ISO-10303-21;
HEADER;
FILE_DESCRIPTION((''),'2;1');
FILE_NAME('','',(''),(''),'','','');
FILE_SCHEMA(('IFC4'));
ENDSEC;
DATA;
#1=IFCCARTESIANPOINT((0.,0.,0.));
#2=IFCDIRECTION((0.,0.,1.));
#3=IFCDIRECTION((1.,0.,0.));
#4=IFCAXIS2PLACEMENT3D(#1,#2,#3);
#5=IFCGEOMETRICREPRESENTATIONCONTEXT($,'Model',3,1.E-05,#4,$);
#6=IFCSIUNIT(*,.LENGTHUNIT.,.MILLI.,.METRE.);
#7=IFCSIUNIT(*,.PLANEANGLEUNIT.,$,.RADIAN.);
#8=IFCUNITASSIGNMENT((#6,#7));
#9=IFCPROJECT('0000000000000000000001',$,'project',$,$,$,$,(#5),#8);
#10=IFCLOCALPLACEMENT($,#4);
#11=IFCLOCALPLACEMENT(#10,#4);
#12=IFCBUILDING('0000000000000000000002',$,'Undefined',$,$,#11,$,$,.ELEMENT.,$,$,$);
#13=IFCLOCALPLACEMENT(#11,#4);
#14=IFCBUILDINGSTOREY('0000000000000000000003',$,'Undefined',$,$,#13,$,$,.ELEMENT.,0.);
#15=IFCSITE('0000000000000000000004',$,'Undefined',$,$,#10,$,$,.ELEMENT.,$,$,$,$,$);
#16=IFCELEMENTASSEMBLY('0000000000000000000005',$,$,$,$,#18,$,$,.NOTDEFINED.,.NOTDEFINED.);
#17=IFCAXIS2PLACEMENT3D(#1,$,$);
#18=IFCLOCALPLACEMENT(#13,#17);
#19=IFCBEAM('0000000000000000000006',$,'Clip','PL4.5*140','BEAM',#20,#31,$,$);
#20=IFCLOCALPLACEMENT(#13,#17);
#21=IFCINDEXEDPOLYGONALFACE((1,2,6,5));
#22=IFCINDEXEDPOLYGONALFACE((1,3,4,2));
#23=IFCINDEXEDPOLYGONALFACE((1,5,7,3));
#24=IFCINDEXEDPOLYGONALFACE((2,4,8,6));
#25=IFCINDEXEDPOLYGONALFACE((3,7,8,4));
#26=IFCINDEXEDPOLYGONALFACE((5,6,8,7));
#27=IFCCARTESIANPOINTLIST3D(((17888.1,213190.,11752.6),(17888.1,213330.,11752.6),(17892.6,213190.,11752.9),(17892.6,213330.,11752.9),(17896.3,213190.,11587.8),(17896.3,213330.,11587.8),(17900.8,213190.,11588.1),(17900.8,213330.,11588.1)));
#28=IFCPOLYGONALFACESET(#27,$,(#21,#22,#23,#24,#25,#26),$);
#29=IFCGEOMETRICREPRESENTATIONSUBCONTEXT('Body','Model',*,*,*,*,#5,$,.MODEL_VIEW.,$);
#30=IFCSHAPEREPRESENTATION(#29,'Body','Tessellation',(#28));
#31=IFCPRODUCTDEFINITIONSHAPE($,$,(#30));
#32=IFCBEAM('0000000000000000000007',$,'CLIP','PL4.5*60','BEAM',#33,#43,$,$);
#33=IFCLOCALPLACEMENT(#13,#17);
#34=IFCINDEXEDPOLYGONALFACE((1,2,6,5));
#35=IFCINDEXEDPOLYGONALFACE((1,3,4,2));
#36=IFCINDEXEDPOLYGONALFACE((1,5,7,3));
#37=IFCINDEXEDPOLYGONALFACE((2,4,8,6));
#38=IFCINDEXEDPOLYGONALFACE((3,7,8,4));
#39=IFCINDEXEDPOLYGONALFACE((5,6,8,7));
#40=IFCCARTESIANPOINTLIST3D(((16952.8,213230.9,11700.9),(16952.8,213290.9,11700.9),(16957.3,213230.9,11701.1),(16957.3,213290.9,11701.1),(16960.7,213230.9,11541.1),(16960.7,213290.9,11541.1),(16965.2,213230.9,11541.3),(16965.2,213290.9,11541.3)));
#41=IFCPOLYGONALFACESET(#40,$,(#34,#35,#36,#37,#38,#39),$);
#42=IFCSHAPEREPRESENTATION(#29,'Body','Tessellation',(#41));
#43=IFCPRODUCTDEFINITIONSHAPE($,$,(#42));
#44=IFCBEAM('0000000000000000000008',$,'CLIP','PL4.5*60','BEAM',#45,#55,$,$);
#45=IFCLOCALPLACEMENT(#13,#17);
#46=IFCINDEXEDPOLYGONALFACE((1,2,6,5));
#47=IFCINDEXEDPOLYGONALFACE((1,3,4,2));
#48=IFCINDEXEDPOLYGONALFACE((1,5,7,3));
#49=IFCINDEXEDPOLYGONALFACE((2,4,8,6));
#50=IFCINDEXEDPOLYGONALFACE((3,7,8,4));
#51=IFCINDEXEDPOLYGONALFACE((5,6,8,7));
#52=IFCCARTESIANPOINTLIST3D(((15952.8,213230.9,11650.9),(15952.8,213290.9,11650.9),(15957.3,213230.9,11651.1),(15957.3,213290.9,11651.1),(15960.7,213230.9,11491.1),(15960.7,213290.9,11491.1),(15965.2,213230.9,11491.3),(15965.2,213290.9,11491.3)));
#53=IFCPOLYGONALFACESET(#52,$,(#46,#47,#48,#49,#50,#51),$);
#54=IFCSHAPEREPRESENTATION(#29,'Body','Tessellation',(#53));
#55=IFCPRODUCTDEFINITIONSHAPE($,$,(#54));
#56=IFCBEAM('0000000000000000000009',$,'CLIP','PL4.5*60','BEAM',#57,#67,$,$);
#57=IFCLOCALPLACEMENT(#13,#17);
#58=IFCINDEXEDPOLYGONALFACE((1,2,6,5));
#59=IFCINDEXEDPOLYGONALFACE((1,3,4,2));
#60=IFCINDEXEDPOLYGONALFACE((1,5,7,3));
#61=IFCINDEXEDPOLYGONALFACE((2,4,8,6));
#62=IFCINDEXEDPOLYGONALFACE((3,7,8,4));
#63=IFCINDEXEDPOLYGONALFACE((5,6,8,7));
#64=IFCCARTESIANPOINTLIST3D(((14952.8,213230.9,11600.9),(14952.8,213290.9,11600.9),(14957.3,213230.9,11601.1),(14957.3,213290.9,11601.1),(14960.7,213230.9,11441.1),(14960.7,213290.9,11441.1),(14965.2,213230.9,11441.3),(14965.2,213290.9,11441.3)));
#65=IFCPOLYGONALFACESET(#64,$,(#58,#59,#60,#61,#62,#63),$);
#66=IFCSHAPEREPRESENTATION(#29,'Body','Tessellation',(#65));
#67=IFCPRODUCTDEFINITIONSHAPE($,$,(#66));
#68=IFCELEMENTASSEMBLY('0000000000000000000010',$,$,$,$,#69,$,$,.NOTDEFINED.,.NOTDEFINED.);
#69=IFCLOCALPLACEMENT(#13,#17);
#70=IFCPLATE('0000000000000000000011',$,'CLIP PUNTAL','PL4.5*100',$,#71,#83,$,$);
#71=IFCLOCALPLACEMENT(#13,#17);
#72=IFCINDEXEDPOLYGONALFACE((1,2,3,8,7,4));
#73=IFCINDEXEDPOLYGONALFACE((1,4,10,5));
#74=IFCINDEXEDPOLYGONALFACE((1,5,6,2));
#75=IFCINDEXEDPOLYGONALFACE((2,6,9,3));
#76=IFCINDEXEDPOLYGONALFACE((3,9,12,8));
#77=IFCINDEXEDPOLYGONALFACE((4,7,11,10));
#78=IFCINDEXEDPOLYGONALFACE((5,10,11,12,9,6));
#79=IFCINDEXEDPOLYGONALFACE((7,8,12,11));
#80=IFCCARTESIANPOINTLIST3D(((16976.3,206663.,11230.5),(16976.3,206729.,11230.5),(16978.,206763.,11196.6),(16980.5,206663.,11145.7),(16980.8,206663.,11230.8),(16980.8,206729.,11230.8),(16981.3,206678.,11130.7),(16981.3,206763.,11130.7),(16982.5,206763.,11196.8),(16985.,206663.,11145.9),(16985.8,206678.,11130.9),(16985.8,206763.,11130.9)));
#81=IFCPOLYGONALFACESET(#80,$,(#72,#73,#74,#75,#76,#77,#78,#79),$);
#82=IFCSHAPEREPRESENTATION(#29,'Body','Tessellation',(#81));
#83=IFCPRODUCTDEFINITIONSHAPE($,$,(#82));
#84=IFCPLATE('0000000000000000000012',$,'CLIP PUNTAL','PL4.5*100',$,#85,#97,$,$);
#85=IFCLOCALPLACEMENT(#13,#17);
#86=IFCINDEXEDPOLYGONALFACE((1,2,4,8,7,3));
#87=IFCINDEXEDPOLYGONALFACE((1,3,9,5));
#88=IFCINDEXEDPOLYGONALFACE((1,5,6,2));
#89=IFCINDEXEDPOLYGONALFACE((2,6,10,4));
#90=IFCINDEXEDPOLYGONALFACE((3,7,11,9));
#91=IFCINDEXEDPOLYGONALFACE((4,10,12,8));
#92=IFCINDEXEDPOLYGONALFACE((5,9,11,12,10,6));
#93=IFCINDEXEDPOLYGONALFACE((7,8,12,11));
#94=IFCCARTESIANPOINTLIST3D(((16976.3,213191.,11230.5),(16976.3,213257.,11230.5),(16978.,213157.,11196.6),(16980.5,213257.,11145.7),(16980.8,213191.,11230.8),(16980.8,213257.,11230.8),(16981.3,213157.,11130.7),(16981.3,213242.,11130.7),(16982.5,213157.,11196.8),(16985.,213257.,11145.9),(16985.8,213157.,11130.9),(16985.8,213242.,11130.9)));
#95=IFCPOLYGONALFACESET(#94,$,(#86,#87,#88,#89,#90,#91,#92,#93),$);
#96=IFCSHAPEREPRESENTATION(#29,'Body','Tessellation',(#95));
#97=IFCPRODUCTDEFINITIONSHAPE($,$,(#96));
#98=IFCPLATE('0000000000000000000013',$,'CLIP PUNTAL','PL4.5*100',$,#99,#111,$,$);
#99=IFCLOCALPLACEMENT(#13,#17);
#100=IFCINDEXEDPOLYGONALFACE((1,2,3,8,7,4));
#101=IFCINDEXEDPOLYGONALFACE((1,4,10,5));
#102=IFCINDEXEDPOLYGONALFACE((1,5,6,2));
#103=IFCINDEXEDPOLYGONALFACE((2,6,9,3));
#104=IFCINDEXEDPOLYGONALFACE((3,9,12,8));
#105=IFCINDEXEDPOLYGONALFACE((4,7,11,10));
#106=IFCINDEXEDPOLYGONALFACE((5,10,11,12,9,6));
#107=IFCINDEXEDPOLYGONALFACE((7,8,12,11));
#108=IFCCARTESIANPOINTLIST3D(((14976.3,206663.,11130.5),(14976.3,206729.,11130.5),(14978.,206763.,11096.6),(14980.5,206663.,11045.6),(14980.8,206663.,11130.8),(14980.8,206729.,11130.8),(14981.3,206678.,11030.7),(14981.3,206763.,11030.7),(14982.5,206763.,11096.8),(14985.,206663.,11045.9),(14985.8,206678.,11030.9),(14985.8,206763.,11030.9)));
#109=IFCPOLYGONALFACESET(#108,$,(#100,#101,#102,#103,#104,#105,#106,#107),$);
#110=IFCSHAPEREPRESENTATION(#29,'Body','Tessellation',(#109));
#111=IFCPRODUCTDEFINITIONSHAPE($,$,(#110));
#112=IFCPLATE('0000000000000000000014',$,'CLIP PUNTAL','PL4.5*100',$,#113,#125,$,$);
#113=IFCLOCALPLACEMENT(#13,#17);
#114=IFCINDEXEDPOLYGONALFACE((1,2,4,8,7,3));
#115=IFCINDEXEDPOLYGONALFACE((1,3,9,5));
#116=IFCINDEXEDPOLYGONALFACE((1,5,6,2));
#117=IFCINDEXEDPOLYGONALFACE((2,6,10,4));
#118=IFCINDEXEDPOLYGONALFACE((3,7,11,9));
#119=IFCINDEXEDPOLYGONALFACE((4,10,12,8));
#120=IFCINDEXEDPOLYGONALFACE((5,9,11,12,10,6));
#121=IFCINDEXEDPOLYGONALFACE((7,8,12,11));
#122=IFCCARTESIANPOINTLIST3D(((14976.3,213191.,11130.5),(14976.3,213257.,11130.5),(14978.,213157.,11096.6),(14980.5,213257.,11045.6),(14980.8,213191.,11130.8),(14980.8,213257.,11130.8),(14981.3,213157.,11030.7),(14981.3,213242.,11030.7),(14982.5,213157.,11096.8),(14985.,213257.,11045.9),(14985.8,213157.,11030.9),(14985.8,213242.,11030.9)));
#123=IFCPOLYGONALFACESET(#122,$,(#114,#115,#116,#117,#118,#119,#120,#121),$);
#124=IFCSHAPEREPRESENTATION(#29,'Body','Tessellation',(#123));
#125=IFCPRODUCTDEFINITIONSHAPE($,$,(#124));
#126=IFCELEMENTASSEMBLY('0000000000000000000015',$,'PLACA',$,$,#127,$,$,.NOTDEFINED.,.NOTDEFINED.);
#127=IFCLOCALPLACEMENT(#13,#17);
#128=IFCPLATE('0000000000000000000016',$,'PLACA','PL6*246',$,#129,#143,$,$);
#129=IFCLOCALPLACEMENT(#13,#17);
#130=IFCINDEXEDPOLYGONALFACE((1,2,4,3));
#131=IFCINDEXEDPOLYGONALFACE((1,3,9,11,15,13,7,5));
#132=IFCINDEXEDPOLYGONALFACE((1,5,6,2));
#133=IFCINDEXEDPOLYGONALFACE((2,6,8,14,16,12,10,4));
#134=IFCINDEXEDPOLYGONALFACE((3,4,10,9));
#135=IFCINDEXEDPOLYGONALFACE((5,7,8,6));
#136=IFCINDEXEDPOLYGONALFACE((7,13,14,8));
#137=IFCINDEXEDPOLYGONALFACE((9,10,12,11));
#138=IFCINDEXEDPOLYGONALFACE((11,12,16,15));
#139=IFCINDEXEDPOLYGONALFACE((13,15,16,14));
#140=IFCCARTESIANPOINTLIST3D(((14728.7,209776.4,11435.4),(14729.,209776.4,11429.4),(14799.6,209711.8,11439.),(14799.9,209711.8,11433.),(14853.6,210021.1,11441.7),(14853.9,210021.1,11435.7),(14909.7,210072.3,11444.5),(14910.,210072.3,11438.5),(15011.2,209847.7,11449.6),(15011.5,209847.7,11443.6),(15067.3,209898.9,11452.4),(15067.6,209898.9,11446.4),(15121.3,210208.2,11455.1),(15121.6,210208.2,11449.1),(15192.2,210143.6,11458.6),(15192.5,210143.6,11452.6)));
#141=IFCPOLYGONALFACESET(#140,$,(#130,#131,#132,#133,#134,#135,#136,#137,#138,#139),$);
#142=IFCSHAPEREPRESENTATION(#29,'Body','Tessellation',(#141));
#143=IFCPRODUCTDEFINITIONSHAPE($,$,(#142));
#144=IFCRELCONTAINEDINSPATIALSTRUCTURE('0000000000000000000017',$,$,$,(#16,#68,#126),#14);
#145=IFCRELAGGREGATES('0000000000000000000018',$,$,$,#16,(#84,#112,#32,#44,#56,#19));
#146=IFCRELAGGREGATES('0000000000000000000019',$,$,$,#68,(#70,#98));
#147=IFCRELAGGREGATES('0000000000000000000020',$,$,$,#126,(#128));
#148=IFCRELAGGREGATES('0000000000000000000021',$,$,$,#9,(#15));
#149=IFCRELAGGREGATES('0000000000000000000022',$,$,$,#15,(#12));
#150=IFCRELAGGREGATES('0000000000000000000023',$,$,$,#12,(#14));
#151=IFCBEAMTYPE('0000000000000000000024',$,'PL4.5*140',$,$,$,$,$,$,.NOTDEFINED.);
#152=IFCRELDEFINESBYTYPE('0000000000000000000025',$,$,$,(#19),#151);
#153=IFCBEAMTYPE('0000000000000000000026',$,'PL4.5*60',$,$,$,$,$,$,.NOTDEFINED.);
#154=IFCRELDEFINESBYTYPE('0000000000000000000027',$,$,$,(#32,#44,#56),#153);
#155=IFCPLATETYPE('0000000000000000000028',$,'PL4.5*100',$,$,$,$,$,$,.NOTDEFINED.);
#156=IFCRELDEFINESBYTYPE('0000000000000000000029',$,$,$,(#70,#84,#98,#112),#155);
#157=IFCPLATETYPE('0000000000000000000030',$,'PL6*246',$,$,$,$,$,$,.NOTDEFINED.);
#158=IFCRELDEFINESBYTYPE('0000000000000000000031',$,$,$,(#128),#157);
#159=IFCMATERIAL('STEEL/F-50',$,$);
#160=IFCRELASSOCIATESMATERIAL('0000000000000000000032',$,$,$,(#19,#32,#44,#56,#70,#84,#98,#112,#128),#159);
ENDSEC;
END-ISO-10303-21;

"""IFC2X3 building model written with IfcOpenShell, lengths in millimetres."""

from ifc_helpers import new_model, si_unit, frame, origin_with_axes, origin_2d_with_axis, place, context, subcontext, project, spatial, polyline, rectangle, outline, extrude, material, type_object, element, aggregate, save


model = new_model("IFC2X3")

# Units and contexts
model_context = context("Model", 3, precision=1e-05, world=origin_with_axes())
body_context = subcontext(model_context, "Body", "Model", "MODEL_VIEW")
ifc_project = project(units=[si_unit("LENGTHUNIT", "METRE", prefix="MILLI"), si_unit("PLANEANGLEUNIT", "RADIAN")], contexts=[model_context])

# Site, building, storey
site_placement = place(None, origin_with_axes())
site = spatial("IfcSite", under=ifc_project, at=site_placement, Name="Undefined", CompositionType="ELEMENT")
building_placement = place(site_placement, origin_with_axes())
building = spatial("IfcBuilding", under=site, at=building_placement, Name="Undefined", CompositionType="ELEMENT")
storey_placement = place(building_placement, origin_with_axes())
storey = spatial("IfcBuildingStorey", under=building, at=storey_placement, Name="Undefined", CompositionType="ELEMENT", Elevation=0.0)

# Element assembly, beams
assembly_1_placement = place(storey_placement, origin_with_axes())
assembly_1 = element("IfcElementAssembly", 1, at=assembly_1_placement, inside=storey, AssemblyPlace="NOTDEFINED", PredefinedType="NOTDEFINED")
ifc_material_1 = material(Name="STEEL/F-50")
beam_type_1 = type_object("IfcBeamType", Name="PL4.5*140", PredefinedType="NOTDEFINED")
beam_1_placement = place(assembly_1_placement, frame((17890.3, 213260.0, 11752.7), z_axis=(0.0, 1.0, 0.0), x_axis=(0.049943, 0.0, -0.998752)))
beam_1 = element("IfcBeam", 2, at=beam_1_placement, type_object=beam_type_1, material=ifc_material_1, Name="Clip", Description="PL4.5*140", ObjectType="BEAM", context=body_context, shape_type="SweptSolid", body=[
    extrude(rectangle(XDim=4.5, YDim=140.0, at=origin_2d_with_axis()), frame((165.0, 0.0, 0.0), z_axis=(-1.0, 0.0, 0.0), x_axis=(0.0, -1.0, 0.0)), (0.0, 0.0, 1.0), 165.0),
])
beam_type_2 = type_object("IfcBeamType", Name="PL4.5*60", PredefinedType="NOTDEFINED")
beam_2_placement = place(assembly_1_placement, frame((16955.0, 213260.9, 11701.0), z_axis=(0.0, -1.0, 0.0), x_axis=(0.049943, 0.0, -0.998752)))
beam_2 = element("IfcBeam", 3, at=beam_2_placement, type_object=beam_type_2, material=ifc_material_1, Name="CLIP", Description="PL4.5*60", ObjectType="BEAM", context=body_context, shape_type="SweptSolid", body=[
    extrude(rectangle(XDim=4.5, YDim=60.0, at=origin_2d_with_axis()), frame((160.0, 0.0, 0.0), z_axis=(-1.0, 0.0, 0.0), x_axis=(0.0, -1.0, 0.0)), (0.0, 0.0, 1.0), 160.0),
])
beam_3_placement = place(assembly_1_placement, frame((15955.0, 213260.9, 11651.0), z_axis=(0.0, -1.0, 0.0), x_axis=(0.049943, 0.0, -0.998752)))
beam_3 = element("IfcBeam", 4, at=beam_3_placement, type_object=beam_type_2, material=ifc_material_1, Name="CLIP", Description="PL4.5*60", ObjectType="BEAM", context=body_context, shape_type="SweptSolid", body=[
    extrude(rectangle(XDim=4.5, YDim=60.0, at=origin_2d_with_axis()), frame((160.0, 0.0, 0.0), z_axis=(-1.0, 0.0, 0.0), x_axis=(0.0, -1.0, 0.0)), (0.0, 0.0, 1.0), 160.0),
])
beam_4_placement = place(assembly_1_placement, frame((14955.0, 213260.9, 11601.0), z_axis=(0.0, -1.0, 0.0), x_axis=(0.049943, 0.0, -0.998752)))
beam_4 = element("IfcBeam", 5, at=beam_4_placement, type_object=beam_type_2, material=ifc_material_1, Name="CLIP", Description="PL4.5*60", ObjectType="BEAM", context=body_context, shape_type="SweptSolid", body=[
    extrude(rectangle(XDim=4.5, YDim=60.0, at=origin_2d_with_axis()), frame((160.0, 0.0, 0.0), z_axis=(-1.0, 0.0, 0.0), x_axis=(0.0, -1.0, 0.0)), (0.0, 0.0, 1.0), 160.0),
])

# Element assembly, plate
assembly_2_placement = place(storey_placement, origin_with_axes())
assembly_2 = element("IfcElementAssembly", 6, at=assembly_2_placement, inside=storey, AssemblyPlace="NOTDEFINED", PredefinedType="NOTDEFINED")
plate_type_1 = type_object("IfcPlateType", Name="PL4.5*100", PredefinedType="NOTDEFINED")
plate_1_placement = place(assembly_2_placement, frame((16978.5, 206663.0, 11230.7), z_axis=(-0.998754, 0.0, -0.049896), x_axis=(0.0, 1.0, 0.0)))
plate_1 = element("IfcPlate", 7, at=plate_1_placement, type_object=plate_type_1, material=ifc_material_1, Name="CLIP PUNTAL", Description="PL4.5*100", context=body_context, shape_type="SweptSolid", body=[
    extrude(outline(polyline([(0.0, 0.0), (66.0, 0.0), (100.0, 34.0), (100.0, 100.0), (15.0, 100.0), (0.0, 85.0), (0.0, 0.0)])), frame((0.0, 0.0, -2.2), z_axis=(0.0, 0.0, 1.0), x_axis=(1.0, 0.0, 0.0)), (0.0, 0.0, 1.0), 4.5),
])

# Plates
plate_2_placement = place(assembly_1_placement, frame((16978.5, 213257.0, 11230.7), z_axis=(0.998754, 0.0, 0.049896), x_axis=(0.0, -1.0, 0.0)))
plate_2 = element("IfcPlate", 8, at=plate_2_placement, type_object=plate_type_1, material=ifc_material_1, Name="CLIP PUNTAL", Description="PL4.5*100", context=body_context, shape_type="SweptSolid", body=[
    extrude(outline(polyline([(0.0, 0.0), (66.0, 0.0), (100.0, 34.0), (100.0, 100.0), (15.0, 100.0), (0.0, 85.0), (0.0, 0.0)])), frame((0.0, 0.0, -2.2), z_axis=(0.0, 0.0, 1.0), x_axis=(1.0, 0.0, 0.0)), (0.0, 0.0, 1.0), 4.5),
])
plate_3_placement = place(assembly_2_placement, frame((14978.5, 206663.0, 11130.6), z_axis=(-0.998754, 0.0, -0.049896), x_axis=(0.0, 1.0, 0.0)))
plate_3 = element("IfcPlate", 9, at=plate_3_placement, type_object=plate_type_1, material=ifc_material_1, Name="CLIP PUNTAL", Description="PL4.5*100", context=body_context, shape_type="SweptSolid", body=[
    extrude(outline(polyline([(0.0, 0.0), (66.0, 0.0), (100.0, 34.0), (100.0, 100.0), (15.0, 100.0), (0.0, 85.0), (0.0, 0.0)])), frame((0.0, 0.0, -2.2), z_axis=(0.0, 0.0, 1.0), x_axis=(1.0, 0.0, 0.0)), (0.0, 0.0, 1.0), 4.5),
])
plate_4_placement = place(assembly_1_placement, frame((14978.5, 213257.0, 11130.6), z_axis=(0.998754, 0.0, 0.049896), x_axis=(0.0, -1.0, 0.0)))
plate_4 = element("IfcPlate", 10, at=plate_4_placement, type_object=plate_type_1, material=ifc_material_1, Name="CLIP PUNTAL", Description="PL4.5*100", context=body_context, shape_type="SweptSolid", body=[
    extrude(outline(polyline([(0.0, 0.0), (66.0, 0.0), (100.0, 34.0), (100.0, 100.0), (15.0, 100.0), (0.0, 85.0), (0.0, 0.0)])), frame((0.0, 0.0, -2.2), z_axis=(0.0, 0.0, 1.0), x_axis=(1.0, 0.0, 0.0)), (0.0, 0.0, 1.0), 4.5),
])

# Element assembly, plate
assembly_3_placement = place(storey_placement, origin_with_axes())
assembly_3 = element("IfcElementAssembly", 11, at=assembly_3_placement, inside=storey, Name="PLACA", AssemblyPlace="NOTDEFINED", PredefinedType="NOTDEFINED")
plate_type_2 = type_object("IfcPlateType", Name="PL6*246", PredefinedType="NOTDEFINED")
plate_5_placement = place(assembly_3_placement, frame((14909.9, 210072.3, 11441.5), z_axis=(-0.049943, 0.0, 0.998752), x_axis=(-0.738599, -0.673133, -0.036934)))
plate_5 = element("IfcPlate", 12, at=plate_5_placement, type_object=plate_type_2, material=ifc_material_1, Name="PLACA", Description="PL6*246", context=body_context, shape_type="SweptSolid", body=[
    extrude(outline(polyline([(0.0, 0.0), (76.0, 0.0), (333.2, 96.8), (324.2, 192.4), (76.0, 234.5), (0.0, 234.5), (-257.2, 137.6), (-248.2, 42.1), (0.0, 0.0)])), frame((0.0, 0.0, -3.0), z_axis=(0.0, 0.0, 1.0), x_axis=(1.0, 0.0, 0.0)), (0.0, 0.0, 1.0), 6.0),
])

aggregate(assembly_1, [plate_2, plate_4, beam_2, beam_3, beam_4, beam_1])
aggregate(assembly_2, [plate_1, plate_3])

aggregate(assembly_3, [plate_5])

save(model, "model.ifc")
